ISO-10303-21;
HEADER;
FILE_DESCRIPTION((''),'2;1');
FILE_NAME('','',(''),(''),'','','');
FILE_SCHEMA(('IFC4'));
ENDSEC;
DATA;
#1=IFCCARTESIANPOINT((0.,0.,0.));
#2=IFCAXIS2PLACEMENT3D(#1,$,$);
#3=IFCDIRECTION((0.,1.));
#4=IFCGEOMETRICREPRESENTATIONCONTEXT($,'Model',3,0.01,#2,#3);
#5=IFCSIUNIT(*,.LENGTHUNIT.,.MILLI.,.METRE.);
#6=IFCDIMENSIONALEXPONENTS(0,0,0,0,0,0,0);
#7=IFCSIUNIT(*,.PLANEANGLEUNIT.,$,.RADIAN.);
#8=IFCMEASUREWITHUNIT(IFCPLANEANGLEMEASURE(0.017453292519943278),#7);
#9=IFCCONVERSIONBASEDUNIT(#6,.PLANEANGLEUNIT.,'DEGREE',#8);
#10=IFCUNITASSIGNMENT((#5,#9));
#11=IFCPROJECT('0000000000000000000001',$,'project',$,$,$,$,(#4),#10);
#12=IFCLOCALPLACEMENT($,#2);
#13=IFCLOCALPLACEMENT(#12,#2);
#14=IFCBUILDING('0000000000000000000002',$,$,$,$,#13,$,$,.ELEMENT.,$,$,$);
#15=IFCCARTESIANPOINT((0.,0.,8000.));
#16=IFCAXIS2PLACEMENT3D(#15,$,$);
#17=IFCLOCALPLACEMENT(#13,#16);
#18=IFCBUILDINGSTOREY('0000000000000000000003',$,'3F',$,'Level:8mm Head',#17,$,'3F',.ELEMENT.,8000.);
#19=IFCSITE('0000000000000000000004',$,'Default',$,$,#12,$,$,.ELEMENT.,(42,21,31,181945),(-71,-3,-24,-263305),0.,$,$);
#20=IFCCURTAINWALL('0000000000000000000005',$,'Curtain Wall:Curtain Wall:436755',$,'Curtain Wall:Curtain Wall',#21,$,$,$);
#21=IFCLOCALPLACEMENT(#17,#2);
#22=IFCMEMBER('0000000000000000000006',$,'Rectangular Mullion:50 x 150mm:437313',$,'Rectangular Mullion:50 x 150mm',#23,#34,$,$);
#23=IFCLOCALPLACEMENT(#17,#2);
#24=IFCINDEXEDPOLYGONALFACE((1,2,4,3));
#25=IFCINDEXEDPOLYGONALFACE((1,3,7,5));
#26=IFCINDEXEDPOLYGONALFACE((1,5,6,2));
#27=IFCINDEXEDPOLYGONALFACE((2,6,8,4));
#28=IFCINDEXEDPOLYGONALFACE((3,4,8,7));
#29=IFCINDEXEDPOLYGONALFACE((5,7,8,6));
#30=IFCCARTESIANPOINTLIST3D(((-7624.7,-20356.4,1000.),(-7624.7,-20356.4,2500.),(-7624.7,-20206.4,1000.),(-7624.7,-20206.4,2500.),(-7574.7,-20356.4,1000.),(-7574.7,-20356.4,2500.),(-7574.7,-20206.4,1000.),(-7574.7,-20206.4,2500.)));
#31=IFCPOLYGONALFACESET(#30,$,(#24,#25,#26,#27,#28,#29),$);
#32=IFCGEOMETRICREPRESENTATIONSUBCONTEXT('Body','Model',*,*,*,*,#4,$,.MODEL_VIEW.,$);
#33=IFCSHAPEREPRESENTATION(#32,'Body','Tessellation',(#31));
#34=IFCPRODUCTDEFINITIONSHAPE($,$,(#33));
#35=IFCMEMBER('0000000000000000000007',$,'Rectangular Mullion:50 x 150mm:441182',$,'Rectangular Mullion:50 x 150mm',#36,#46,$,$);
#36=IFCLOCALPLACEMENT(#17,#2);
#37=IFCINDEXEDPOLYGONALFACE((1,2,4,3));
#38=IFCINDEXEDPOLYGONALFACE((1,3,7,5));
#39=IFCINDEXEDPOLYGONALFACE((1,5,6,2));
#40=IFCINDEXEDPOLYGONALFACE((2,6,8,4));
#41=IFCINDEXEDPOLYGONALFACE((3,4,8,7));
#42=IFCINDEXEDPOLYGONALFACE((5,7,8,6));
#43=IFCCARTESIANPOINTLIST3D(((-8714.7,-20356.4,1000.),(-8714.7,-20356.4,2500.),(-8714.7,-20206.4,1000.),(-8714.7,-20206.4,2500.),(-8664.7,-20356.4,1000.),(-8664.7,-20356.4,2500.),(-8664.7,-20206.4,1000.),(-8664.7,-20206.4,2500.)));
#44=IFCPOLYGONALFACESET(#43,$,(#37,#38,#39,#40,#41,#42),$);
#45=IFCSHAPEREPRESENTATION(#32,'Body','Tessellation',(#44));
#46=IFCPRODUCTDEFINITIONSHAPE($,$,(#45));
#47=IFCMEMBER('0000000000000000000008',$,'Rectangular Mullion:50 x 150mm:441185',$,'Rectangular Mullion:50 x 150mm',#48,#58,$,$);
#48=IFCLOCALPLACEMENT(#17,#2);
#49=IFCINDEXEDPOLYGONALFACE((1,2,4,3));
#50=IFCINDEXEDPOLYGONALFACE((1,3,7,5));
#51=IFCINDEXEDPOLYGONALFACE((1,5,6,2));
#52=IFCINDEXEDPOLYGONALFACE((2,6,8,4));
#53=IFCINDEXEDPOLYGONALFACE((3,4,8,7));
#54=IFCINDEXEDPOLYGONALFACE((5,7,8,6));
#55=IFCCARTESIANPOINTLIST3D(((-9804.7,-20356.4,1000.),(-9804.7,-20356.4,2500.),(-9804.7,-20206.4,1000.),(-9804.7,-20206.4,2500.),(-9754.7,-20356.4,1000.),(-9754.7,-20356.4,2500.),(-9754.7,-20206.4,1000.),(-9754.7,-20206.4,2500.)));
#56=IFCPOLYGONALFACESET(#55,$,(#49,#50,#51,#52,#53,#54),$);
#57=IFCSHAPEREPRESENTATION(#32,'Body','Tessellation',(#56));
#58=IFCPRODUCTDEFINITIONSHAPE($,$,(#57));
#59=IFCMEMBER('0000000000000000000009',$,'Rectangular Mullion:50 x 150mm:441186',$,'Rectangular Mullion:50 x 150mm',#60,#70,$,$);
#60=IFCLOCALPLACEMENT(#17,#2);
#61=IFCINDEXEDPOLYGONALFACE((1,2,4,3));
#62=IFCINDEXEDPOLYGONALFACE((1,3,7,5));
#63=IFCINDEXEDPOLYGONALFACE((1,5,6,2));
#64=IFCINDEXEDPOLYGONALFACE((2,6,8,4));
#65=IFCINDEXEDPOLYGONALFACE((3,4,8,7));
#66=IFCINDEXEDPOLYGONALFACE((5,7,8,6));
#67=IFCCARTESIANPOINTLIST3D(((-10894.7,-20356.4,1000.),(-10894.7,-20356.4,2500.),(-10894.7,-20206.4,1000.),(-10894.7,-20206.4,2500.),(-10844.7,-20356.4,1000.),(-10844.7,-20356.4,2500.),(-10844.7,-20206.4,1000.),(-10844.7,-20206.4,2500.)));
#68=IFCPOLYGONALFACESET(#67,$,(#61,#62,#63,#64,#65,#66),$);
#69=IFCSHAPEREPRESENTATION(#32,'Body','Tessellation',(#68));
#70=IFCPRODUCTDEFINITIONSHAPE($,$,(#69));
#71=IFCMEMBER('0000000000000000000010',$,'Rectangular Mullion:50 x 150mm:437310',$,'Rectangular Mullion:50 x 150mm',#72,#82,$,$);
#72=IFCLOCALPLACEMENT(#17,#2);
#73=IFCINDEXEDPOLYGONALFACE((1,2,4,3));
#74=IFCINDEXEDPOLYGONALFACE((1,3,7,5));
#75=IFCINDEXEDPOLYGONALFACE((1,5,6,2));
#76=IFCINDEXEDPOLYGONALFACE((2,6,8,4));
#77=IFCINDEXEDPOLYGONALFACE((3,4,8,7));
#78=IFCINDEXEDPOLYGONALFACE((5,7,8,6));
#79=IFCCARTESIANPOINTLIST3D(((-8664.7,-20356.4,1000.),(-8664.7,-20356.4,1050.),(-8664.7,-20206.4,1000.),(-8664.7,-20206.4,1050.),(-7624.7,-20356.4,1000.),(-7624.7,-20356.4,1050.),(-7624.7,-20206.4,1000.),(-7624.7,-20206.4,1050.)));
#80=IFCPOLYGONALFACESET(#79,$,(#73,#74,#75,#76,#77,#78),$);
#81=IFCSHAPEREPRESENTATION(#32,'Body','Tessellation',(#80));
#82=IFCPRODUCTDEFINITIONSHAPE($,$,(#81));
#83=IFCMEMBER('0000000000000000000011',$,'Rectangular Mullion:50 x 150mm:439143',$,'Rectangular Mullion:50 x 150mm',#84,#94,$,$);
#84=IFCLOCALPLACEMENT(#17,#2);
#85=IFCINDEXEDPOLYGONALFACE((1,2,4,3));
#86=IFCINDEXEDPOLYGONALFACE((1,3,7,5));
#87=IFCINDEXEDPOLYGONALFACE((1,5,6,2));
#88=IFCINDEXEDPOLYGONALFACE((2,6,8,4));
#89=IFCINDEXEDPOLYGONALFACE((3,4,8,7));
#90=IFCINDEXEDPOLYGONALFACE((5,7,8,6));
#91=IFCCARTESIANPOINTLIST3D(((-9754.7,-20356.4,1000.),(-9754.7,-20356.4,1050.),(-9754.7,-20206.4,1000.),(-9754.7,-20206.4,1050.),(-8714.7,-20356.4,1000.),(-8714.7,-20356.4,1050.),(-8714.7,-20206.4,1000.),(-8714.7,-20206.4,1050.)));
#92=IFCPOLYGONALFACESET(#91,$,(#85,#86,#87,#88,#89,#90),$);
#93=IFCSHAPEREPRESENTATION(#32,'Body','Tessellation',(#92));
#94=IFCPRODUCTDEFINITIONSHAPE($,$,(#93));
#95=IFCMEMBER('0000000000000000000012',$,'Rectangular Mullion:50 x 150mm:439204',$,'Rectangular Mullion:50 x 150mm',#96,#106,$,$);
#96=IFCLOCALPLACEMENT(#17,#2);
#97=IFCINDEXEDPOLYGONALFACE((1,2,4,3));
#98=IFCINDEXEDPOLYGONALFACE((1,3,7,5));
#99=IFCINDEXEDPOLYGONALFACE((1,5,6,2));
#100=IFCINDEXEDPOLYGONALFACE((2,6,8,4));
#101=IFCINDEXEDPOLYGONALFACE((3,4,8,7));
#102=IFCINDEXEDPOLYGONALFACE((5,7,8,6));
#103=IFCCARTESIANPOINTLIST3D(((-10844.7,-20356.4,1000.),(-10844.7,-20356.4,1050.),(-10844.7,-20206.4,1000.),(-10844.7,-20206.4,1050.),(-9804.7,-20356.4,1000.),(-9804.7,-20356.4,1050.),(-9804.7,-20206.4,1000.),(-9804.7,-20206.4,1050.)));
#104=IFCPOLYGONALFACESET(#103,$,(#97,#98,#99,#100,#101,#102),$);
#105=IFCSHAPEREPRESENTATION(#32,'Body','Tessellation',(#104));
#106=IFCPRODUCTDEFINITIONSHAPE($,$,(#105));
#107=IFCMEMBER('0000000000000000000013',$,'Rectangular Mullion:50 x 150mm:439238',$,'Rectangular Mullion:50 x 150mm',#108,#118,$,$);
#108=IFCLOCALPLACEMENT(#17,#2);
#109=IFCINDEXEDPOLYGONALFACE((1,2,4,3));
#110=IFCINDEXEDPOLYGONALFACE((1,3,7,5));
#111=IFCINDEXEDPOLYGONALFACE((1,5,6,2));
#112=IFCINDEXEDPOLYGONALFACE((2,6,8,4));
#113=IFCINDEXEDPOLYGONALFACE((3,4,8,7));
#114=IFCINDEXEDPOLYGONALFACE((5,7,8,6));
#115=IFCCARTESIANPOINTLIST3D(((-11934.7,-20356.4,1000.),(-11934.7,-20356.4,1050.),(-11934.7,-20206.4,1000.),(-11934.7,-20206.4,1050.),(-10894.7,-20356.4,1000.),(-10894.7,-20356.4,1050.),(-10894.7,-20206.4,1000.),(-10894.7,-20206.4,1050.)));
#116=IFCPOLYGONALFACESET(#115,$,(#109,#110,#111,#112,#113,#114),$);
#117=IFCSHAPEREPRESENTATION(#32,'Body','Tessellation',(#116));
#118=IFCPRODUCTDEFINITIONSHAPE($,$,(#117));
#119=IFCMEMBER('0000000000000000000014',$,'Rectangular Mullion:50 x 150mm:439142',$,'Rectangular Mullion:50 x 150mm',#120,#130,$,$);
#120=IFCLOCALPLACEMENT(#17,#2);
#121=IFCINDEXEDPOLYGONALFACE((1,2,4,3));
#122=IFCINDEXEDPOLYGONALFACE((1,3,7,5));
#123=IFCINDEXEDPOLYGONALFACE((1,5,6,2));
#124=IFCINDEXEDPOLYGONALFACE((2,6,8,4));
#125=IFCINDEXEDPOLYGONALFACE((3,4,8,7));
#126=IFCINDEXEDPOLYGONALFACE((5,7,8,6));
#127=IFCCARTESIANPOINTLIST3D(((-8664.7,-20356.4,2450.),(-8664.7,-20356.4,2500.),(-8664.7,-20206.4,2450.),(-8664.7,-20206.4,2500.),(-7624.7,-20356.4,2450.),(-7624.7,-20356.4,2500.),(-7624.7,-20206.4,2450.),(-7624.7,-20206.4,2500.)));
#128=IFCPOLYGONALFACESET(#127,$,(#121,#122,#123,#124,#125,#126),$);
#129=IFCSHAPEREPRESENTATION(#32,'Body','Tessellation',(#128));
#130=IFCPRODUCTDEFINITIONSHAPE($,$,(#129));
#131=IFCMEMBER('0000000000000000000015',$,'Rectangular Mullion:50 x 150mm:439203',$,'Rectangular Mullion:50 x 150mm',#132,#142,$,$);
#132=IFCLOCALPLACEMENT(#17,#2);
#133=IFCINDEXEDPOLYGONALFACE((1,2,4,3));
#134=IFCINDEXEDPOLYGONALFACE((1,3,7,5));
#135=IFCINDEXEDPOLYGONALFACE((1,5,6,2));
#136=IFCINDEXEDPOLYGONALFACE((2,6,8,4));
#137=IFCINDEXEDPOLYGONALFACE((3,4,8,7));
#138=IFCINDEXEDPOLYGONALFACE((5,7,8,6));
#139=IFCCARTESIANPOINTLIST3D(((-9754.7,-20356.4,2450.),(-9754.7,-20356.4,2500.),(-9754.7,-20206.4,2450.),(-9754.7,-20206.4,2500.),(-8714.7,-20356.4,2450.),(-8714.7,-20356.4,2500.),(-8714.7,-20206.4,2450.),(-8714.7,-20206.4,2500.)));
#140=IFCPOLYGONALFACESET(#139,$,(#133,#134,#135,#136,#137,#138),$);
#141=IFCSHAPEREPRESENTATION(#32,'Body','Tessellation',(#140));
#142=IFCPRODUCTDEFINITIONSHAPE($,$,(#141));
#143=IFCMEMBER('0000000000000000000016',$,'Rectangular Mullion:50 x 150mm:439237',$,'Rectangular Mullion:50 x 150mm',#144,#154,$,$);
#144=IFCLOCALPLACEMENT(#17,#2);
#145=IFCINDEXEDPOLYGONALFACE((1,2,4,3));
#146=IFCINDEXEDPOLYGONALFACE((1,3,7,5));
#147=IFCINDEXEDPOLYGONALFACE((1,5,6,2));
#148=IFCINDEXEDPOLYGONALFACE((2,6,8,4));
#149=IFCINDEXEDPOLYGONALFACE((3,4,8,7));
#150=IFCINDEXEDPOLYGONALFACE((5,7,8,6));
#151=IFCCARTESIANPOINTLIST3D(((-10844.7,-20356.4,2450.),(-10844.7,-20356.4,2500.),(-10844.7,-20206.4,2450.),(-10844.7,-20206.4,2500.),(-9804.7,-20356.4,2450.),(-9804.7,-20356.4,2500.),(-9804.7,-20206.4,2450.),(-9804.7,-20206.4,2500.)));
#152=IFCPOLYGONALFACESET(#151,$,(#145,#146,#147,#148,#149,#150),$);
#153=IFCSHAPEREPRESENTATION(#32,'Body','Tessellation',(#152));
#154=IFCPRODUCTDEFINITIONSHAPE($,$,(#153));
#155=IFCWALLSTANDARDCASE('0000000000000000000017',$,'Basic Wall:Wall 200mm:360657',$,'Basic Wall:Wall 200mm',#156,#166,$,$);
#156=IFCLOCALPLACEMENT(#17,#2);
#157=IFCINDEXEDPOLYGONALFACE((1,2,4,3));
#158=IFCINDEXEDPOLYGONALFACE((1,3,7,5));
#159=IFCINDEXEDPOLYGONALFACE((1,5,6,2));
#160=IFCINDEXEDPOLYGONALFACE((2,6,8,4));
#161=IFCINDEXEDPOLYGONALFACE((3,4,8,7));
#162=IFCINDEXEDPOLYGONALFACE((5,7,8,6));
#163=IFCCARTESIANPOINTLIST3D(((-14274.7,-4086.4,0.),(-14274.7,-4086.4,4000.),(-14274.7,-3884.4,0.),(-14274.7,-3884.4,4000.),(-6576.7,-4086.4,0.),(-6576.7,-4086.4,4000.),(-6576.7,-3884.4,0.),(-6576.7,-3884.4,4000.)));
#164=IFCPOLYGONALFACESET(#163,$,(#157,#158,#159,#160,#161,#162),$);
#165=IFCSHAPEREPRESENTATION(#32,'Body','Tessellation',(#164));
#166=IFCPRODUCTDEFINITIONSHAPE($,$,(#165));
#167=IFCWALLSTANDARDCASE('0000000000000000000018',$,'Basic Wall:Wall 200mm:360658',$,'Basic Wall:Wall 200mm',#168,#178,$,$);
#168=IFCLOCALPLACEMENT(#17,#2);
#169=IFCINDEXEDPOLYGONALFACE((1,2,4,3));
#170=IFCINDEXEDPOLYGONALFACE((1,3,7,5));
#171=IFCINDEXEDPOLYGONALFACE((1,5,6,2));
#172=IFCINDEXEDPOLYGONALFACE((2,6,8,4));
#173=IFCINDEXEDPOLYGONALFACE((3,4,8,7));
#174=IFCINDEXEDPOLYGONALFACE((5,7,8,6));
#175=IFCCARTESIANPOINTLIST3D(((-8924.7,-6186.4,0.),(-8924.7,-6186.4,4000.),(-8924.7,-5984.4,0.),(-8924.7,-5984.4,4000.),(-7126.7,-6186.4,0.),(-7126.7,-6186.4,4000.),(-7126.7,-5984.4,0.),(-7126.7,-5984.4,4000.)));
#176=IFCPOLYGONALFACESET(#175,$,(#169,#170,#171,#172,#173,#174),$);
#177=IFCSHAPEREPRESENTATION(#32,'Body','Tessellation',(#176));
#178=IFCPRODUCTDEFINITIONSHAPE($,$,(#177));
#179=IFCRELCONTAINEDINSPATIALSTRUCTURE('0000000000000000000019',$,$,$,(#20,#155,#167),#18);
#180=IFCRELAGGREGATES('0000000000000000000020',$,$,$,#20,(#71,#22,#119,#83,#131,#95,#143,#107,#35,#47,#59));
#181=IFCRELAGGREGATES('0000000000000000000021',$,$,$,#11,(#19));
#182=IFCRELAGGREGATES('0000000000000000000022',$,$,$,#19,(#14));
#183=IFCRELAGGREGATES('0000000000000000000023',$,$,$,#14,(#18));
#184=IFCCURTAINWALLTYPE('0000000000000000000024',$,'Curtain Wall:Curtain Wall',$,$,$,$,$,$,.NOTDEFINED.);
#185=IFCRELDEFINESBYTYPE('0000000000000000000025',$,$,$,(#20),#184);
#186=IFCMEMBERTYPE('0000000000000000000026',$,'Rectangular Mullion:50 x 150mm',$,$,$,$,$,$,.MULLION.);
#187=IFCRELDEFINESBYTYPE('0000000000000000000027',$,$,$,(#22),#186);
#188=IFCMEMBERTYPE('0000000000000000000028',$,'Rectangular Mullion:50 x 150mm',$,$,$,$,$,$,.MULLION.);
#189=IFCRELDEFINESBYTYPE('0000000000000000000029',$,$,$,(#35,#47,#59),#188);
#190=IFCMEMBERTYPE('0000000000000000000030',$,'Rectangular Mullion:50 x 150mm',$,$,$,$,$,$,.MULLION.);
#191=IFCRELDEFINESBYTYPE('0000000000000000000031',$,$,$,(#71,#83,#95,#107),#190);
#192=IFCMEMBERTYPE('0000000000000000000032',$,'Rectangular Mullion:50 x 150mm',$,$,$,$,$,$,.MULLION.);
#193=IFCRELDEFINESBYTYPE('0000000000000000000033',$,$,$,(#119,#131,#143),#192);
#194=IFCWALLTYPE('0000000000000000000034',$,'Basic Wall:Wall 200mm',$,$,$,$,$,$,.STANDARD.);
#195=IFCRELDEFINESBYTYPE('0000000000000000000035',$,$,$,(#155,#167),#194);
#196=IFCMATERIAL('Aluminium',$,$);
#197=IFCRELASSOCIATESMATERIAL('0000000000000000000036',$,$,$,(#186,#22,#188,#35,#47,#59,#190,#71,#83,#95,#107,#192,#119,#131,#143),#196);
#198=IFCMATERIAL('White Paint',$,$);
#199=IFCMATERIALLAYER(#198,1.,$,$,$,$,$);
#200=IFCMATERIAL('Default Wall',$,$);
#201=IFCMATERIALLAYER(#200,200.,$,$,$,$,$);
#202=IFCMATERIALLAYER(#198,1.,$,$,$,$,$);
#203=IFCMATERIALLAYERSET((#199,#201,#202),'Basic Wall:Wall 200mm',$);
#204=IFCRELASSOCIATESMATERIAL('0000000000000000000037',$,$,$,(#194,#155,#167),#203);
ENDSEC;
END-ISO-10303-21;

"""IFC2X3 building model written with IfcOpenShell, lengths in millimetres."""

from ifc_helpers import new_model, entity, si_unit, converted_unit, direction, frame, frame_2d, origin, origin_2d_with_axis, place, context, subcontext, project, spatial, rectangle, extrude, source, transform, mapped, material, layer, layer_set, layer_usage, type_object, type_shapes, element, aggregate, save


model = new_model("IFC2X3")

# Units and contexts
model_context = context("Model", 3, precision=0.01, world=origin(), true_north=direction((0.0, 1.0)))
body_context = subcontext(model_context, "Body", "Model", "MODEL_VIEW")
ifc_project = project(units=[si_unit("LENGTHUNIT", "METRE", prefix="MILLI"), converted_unit("PLANEANGLEUNIT", "DEGREE", entity("IfcPlaneAngleMeasure", 0.017453292519943278), si_unit("PLANEANGLEUNIT", "RADIAN"), dimensions=[0, 0, 0, 0, 0, 0, 0])], contexts=[model_context])

# Site, building, storey
site_placement = place(None, origin())
site = spatial("IfcSite", under=ifc_project, at=site_placement, Name="Default", CompositionType="ELEMENT", RefLatitude=(42, 21, 31, 181945), RefLongitude=(-71, -3, -24, -263305), RefElevation=0.0)
building_placement = place(site_placement, origin())
building = spatial("IfcBuilding", under=site, at=building_placement, CompositionType="ELEMENT")
storey_placement = place(building_placement, frame((0.0, 0.0, 8000.0)))
storey = spatial("IfcBuildingStorey", under=building, at=storey_placement, Name="3F", ObjectType="Level:8mm Head", LongName="3F", CompositionType="ELEMENT", Elevation=8000.0)

# Shared definitions
ifc_material_1 = material(Name="White Paint")

# Curtain wall, members
curtain_wall_type = type_object("IfcCurtainWallType", Name="Curtain Wall:Curtain Wall", PredefinedType="NOTDEFINED")
curtain_wall_placement = place(storey_placement, frame((0.0, 0.0, -8000.0)))
curtain_wall = element("IfcCurtainWall", 1, at=curtain_wall_placement, inside=storey, type_object=curtain_wall_type, Name="Curtain Wall:Curtain Wall:436755", ObjectType="Curtain Wall:Curtain Wall")
ifc_material_2 = material(Name="Aluminium")
member_type_1 = type_object("IfcMemberType", Name="Rectangular Mullion:50 x 150mm", PredefinedType="MULLION", material=ifc_material_2)
shared_shape_1 = source(origin(), body_context, "Body", "SweptSolid", [
    extrude(rectangle(XDim=50.0, YDim=150.0, at=origin_2d_with_axis()), frame((-25.0, 0.0, -1500.0), z_axis=(0.0, 0.0, 1.0), x_axis=(-1.0, 0.0, 0.0)), (0.0, 0.0, 1.0), 1500.0),
])
type_shapes(member_type_1, [shared_shape_1])
member_1_placement = place(curtain_wall_placement, frame((-7574.7, -20281.4, 10500.0)))
member_1 = element("IfcMember", 2, at=member_1_placement, type_object=member_type_1, material=ifc_material_2, Name="Rectangular Mullion:50 x 150mm:437313", ObjectType="Rectangular Mullion:50 x 150mm", context=body_context, shape_type="MappedRepresentation", body=[
    mapped(shared_shape_1, transform((0.0, 0.0, 0.0), scale=1.0)),
])
member_type_2 = type_object("IfcMemberType", Name="Rectangular Mullion:50 x 150mm", PredefinedType="MULLION", material=ifc_material_2)
shared_shape_2 = source(origin(), body_context, "Body", "SweptSolid", [
    extrude(rectangle(XDim=50.0, YDim=150.0, at=origin_2d_with_axis()), frame((0.0, 0.0, -1500.0), z_axis=(0.0, 0.0, 1.0), x_axis=(-1.0, 0.0, 0.0)), (0.0, 0.0, 1.0), 1500.0),
])
type_shapes(member_type_2, [shared_shape_2])
member_2_placement = place(curtain_wall_placement, frame((-8689.7, -20281.4, 9000.0), z_axis=(0.0, 0.0, -1.0), x_axis=(-1.0, 0.0, 0.0)))
member_2 = element("IfcMember", 3, at=member_2_placement, type_object=member_type_2, material=ifc_material_2, Name="Rectangular Mullion:50 x 150mm:441182", ObjectType="Rectangular Mullion:50 x 150mm", context=body_context, shape_type="MappedRepresentation", body=[
    mapped(shared_shape_2, transform((0.0, 0.0, 0.0), scale=1.0)),
])
member_3_placement = place(curtain_wall_placement, frame((-9779.7, -20281.4, 9000.0), z_axis=(0.0, 0.0, -1.0), x_axis=(-1.0, 0.0, 0.0)))
member_3 = element("IfcMember", 4, at=member_3_placement, type_object=member_type_2, material=ifc_material_2, Name="Rectangular Mullion:50 x 150mm:441185", ObjectType="Rectangular Mullion:50 x 150mm", context=body_context, shape_type="MappedRepresentation", body=[
    mapped(shared_shape_2, transform((0.0, 0.0, 0.0), scale=1.0)),
])
member_4_placement = place(curtain_wall_placement, frame((-10869.7, -20281.4, 9000.0), z_axis=(0.0, 0.0, -1.0), x_axis=(-1.0, 0.0, 0.0)))
member_4 = element("IfcMember", 5, at=member_4_placement, type_object=member_type_2, material=ifc_material_2, Name="Rectangular Mullion:50 x 150mm:441186", ObjectType="Rectangular Mullion:50 x 150mm", context=body_context, shape_type="MappedRepresentation", body=[
    mapped(shared_shape_2, transform((0.0, 0.0, 0.0), scale=1.0)),
])
member_type_3 = type_object("IfcMemberType", Name="Rectangular Mullion:50 x 150mm", PredefinedType="MULLION", material=ifc_material_2)
shared_shape_3 = source(origin(), body_context, "Body", "SweptSolid", [
    extrude(rectangle(XDim=50.0, YDim=150.0, at=origin_2d_with_axis()), frame((-25.0, 0.0, -1040.0), z_axis=(0.0, 0.0, 1.0), x_axis=(-1.0, 0.0, 0.0)), (0.0, 0.0, 1.0), 1040.0),
])
type_shapes(member_type_3, [shared_shape_3])
member_5_placement = place(curtain_wall_placement, frame((-7624.7, -20281.4, 9000.0), z_axis=(1.0, 0.0, 0.0), x_axis=(0.0, 0.0, -1.0)))
member_5 = element("IfcMember", 6, at=member_5_placement, type_object=member_type_3, material=ifc_material_2, Name="Rectangular Mullion:50 x 150mm:437310", ObjectType="Rectangular Mullion:50 x 150mm", context=body_context, shape_type="MappedRepresentation", body=[
    mapped(shared_shape_3, transform((0.0, 0.0, 0.0), scale=1.0)),
])
member_6_placement = place(curtain_wall_placement, frame((-8714.7, -20281.4, 9000.0), z_axis=(1.0, 0.0, 0.0), x_axis=(0.0, 0.0, -1.0)))
member_6 = element("IfcMember", 7, at=member_6_placement, type_object=member_type_3, material=ifc_material_2, Name="Rectangular Mullion:50 x 150mm:439143", ObjectType="Rectangular Mullion:50 x 150mm", context=body_context, shape_type="MappedRepresentation", body=[
    mapped(shared_shape_3, transform((0.0, 0.0, 0.0), scale=1.0)),
])
member_7_placement = place(curtain_wall_placement, frame((-9804.7, -20281.4, 9000.0), z_axis=(1.0, 0.0, 0.0), x_axis=(0.0, 0.0, -1.0)))
member_7 = element("IfcMember", 8, at=member_7_placement, type_object=member_type_3, material=ifc_material_2, Name="Rectangular Mullion:50 x 150mm:439204", ObjectType="Rectangular Mullion:50 x 150mm", context=body_context, shape_type="MappedRepresentation", body=[
    mapped(shared_shape_3, transform((0.0, 0.0, 0.0), scale=1.0)),
])
member_8_placement = place(curtain_wall_placement, frame((-10894.7, -20281.4, 9000.0), z_axis=(1.0, 0.0, 0.0), x_axis=(0.0, 0.0, -1.0)))
member_8 = element("IfcMember", 9, at=member_8_placement, type_object=member_type_3, material=ifc_material_2, Name="Rectangular Mullion:50 x 150mm:439238", ObjectType="Rectangular Mullion:50 x 150mm", context=body_context, shape_type="MappedRepresentation", body=[
    mapped(shared_shape_3, transform((0.0, 0.0, 0.0), scale=1.0)),
])
member_type_4 = type_object("IfcMemberType", Name="Rectangular Mullion:50 x 150mm", PredefinedType="MULLION", material=ifc_material_2)
shared_shape_4 = source(origin(), body_context, "Body", "SweptSolid", [
    extrude(rectangle(XDim=50.0, YDim=150.0, at=origin_2d_with_axis()), frame((-25.0, 0.0, -1040.0), z_axis=(0.0, 0.0, 1.0), x_axis=(-1.0, 0.0, 0.0)), (0.0, 0.0, 1.0), 1040.0),
])
type_shapes(member_type_4, [shared_shape_4])
member_9_placement = place(curtain_wall_placement, frame((-8664.7, -20281.4, 10500.0), z_axis=(-1.0, 0.0, 0.0), x_axis=(0.0, 0.0, 1.0)))
member_9 = element("IfcMember", 10, at=member_9_placement, type_object=member_type_4, material=ifc_material_2, Name="Rectangular Mullion:50 x 150mm:439142", ObjectType="Rectangular Mullion:50 x 150mm", context=body_context, shape_type="MappedRepresentation", body=[
    mapped(shared_shape_4, transform((0.0, 0.0, 0.0), scale=1.0)),
])
member_10_placement = place(curtain_wall_placement, frame((-9754.7, -20281.4, 10500.0), z_axis=(-1.0, 0.0, 0.0), x_axis=(0.0, 0.0, 1.0)))
member_10 = element("IfcMember", 11, at=member_10_placement, type_object=member_type_4, material=ifc_material_2, Name="Rectangular Mullion:50 x 150mm:439203", ObjectType="Rectangular Mullion:50 x 150mm", context=body_context, shape_type="MappedRepresentation", body=[
    mapped(shared_shape_4, transform((0.0, 0.0, 0.0), scale=1.0)),
])
member_11_placement = place(curtain_wall_placement, frame((-10844.7, -20281.4, 10500.0), z_axis=(-1.0, 0.0, 0.0), x_axis=(0.0, 0.0, 1.0)))
member_11 = element("IfcMember", 12, at=member_11_placement, type_object=member_type_4, material=ifc_material_2, Name="Rectangular Mullion:50 x 150mm:439237", ObjectType="Rectangular Mullion:50 x 150mm", context=body_context, shape_type="MappedRepresentation", body=[
    mapped(shared_shape_4, transform((0.0, 0.0, 0.0), scale=1.0)),
])
aggregate(curtain_wall, [member_5, member_1, member_9, member_6, member_10, member_7, member_11, member_8, member_2, member_3, member_4])

# Walls
ifc_layer_1 = layer(ifc_material_1, 1.0)
ifc_material_3 = material(Name="Default Wall")
ifc_layer_2 = layer(ifc_material_3, 200.0)
ifc_layer_3 = layer(ifc_material_1, 1.0)
ifc_layer_set = layer_set([ifc_layer_1, ifc_layer_2, ifc_layer_3], Name="Basic Wall:Wall 200mm")
ifc_layer_usage_1 = layer_usage(ifc_layer_set, "AXIS2", "NEGATIVE", 101.0)
wall_type = type_object("IfcWallType", Name="Basic Wall:Wall 200mm", PredefinedType="STANDARD", material=ifc_layer_set)
wall_1_placement = place(storey_placement, frame((-6576.7, -3985.4, 0.0), z_axis=(0.0, 0.0, 1.0), x_axis=(-1.0, 0.0, 0.0)))
element("IfcWallStandardCase", 13, at=wall_1_placement, inside=storey, type_object=wall_type, material=ifc_layer_usage_1, Name="Basic Wall:Wall 200mm:360657", ObjectType="Basic Wall:Wall 200mm", context=body_context, shape_type="SweptSolid", body=[
    extrude(rectangle(XDim=7698.0, YDim=202.0, at=frame_2d((3849.0, 0.0), x_axis=(-1.0, 0.0))), origin(), (0.0, 0.0, 1.0), 4000.0),
])
ifc_layer_usage_2 = layer_usage(ifc_layer_set, "AXIS2", "NEGATIVE", 101.0)
wall_2_placement = place(storey_placement, frame((-7126.7, -6085.4, 0.0), z_axis=(0.0, 0.0, 1.0), x_axis=(-1.0, 0.0, 0.0)))
element("IfcWallStandardCase", 14, at=wall_2_placement, inside=storey, type_object=wall_type, material=ifc_layer_usage_2, Name="Basic Wall:Wall 200mm:360658", ObjectType="Basic Wall:Wall 200mm", context=body_context, shape_type="SweptSolid", body=[
    extrude(rectangle(XDim=1798.0, YDim=202.0, at=frame_2d((899.0, 0.0), x_axis=(-1.0, 0.0))), origin(), (0.0, 0.0, 1.0), 4000.0),
])

save(model, "model.ifc")
